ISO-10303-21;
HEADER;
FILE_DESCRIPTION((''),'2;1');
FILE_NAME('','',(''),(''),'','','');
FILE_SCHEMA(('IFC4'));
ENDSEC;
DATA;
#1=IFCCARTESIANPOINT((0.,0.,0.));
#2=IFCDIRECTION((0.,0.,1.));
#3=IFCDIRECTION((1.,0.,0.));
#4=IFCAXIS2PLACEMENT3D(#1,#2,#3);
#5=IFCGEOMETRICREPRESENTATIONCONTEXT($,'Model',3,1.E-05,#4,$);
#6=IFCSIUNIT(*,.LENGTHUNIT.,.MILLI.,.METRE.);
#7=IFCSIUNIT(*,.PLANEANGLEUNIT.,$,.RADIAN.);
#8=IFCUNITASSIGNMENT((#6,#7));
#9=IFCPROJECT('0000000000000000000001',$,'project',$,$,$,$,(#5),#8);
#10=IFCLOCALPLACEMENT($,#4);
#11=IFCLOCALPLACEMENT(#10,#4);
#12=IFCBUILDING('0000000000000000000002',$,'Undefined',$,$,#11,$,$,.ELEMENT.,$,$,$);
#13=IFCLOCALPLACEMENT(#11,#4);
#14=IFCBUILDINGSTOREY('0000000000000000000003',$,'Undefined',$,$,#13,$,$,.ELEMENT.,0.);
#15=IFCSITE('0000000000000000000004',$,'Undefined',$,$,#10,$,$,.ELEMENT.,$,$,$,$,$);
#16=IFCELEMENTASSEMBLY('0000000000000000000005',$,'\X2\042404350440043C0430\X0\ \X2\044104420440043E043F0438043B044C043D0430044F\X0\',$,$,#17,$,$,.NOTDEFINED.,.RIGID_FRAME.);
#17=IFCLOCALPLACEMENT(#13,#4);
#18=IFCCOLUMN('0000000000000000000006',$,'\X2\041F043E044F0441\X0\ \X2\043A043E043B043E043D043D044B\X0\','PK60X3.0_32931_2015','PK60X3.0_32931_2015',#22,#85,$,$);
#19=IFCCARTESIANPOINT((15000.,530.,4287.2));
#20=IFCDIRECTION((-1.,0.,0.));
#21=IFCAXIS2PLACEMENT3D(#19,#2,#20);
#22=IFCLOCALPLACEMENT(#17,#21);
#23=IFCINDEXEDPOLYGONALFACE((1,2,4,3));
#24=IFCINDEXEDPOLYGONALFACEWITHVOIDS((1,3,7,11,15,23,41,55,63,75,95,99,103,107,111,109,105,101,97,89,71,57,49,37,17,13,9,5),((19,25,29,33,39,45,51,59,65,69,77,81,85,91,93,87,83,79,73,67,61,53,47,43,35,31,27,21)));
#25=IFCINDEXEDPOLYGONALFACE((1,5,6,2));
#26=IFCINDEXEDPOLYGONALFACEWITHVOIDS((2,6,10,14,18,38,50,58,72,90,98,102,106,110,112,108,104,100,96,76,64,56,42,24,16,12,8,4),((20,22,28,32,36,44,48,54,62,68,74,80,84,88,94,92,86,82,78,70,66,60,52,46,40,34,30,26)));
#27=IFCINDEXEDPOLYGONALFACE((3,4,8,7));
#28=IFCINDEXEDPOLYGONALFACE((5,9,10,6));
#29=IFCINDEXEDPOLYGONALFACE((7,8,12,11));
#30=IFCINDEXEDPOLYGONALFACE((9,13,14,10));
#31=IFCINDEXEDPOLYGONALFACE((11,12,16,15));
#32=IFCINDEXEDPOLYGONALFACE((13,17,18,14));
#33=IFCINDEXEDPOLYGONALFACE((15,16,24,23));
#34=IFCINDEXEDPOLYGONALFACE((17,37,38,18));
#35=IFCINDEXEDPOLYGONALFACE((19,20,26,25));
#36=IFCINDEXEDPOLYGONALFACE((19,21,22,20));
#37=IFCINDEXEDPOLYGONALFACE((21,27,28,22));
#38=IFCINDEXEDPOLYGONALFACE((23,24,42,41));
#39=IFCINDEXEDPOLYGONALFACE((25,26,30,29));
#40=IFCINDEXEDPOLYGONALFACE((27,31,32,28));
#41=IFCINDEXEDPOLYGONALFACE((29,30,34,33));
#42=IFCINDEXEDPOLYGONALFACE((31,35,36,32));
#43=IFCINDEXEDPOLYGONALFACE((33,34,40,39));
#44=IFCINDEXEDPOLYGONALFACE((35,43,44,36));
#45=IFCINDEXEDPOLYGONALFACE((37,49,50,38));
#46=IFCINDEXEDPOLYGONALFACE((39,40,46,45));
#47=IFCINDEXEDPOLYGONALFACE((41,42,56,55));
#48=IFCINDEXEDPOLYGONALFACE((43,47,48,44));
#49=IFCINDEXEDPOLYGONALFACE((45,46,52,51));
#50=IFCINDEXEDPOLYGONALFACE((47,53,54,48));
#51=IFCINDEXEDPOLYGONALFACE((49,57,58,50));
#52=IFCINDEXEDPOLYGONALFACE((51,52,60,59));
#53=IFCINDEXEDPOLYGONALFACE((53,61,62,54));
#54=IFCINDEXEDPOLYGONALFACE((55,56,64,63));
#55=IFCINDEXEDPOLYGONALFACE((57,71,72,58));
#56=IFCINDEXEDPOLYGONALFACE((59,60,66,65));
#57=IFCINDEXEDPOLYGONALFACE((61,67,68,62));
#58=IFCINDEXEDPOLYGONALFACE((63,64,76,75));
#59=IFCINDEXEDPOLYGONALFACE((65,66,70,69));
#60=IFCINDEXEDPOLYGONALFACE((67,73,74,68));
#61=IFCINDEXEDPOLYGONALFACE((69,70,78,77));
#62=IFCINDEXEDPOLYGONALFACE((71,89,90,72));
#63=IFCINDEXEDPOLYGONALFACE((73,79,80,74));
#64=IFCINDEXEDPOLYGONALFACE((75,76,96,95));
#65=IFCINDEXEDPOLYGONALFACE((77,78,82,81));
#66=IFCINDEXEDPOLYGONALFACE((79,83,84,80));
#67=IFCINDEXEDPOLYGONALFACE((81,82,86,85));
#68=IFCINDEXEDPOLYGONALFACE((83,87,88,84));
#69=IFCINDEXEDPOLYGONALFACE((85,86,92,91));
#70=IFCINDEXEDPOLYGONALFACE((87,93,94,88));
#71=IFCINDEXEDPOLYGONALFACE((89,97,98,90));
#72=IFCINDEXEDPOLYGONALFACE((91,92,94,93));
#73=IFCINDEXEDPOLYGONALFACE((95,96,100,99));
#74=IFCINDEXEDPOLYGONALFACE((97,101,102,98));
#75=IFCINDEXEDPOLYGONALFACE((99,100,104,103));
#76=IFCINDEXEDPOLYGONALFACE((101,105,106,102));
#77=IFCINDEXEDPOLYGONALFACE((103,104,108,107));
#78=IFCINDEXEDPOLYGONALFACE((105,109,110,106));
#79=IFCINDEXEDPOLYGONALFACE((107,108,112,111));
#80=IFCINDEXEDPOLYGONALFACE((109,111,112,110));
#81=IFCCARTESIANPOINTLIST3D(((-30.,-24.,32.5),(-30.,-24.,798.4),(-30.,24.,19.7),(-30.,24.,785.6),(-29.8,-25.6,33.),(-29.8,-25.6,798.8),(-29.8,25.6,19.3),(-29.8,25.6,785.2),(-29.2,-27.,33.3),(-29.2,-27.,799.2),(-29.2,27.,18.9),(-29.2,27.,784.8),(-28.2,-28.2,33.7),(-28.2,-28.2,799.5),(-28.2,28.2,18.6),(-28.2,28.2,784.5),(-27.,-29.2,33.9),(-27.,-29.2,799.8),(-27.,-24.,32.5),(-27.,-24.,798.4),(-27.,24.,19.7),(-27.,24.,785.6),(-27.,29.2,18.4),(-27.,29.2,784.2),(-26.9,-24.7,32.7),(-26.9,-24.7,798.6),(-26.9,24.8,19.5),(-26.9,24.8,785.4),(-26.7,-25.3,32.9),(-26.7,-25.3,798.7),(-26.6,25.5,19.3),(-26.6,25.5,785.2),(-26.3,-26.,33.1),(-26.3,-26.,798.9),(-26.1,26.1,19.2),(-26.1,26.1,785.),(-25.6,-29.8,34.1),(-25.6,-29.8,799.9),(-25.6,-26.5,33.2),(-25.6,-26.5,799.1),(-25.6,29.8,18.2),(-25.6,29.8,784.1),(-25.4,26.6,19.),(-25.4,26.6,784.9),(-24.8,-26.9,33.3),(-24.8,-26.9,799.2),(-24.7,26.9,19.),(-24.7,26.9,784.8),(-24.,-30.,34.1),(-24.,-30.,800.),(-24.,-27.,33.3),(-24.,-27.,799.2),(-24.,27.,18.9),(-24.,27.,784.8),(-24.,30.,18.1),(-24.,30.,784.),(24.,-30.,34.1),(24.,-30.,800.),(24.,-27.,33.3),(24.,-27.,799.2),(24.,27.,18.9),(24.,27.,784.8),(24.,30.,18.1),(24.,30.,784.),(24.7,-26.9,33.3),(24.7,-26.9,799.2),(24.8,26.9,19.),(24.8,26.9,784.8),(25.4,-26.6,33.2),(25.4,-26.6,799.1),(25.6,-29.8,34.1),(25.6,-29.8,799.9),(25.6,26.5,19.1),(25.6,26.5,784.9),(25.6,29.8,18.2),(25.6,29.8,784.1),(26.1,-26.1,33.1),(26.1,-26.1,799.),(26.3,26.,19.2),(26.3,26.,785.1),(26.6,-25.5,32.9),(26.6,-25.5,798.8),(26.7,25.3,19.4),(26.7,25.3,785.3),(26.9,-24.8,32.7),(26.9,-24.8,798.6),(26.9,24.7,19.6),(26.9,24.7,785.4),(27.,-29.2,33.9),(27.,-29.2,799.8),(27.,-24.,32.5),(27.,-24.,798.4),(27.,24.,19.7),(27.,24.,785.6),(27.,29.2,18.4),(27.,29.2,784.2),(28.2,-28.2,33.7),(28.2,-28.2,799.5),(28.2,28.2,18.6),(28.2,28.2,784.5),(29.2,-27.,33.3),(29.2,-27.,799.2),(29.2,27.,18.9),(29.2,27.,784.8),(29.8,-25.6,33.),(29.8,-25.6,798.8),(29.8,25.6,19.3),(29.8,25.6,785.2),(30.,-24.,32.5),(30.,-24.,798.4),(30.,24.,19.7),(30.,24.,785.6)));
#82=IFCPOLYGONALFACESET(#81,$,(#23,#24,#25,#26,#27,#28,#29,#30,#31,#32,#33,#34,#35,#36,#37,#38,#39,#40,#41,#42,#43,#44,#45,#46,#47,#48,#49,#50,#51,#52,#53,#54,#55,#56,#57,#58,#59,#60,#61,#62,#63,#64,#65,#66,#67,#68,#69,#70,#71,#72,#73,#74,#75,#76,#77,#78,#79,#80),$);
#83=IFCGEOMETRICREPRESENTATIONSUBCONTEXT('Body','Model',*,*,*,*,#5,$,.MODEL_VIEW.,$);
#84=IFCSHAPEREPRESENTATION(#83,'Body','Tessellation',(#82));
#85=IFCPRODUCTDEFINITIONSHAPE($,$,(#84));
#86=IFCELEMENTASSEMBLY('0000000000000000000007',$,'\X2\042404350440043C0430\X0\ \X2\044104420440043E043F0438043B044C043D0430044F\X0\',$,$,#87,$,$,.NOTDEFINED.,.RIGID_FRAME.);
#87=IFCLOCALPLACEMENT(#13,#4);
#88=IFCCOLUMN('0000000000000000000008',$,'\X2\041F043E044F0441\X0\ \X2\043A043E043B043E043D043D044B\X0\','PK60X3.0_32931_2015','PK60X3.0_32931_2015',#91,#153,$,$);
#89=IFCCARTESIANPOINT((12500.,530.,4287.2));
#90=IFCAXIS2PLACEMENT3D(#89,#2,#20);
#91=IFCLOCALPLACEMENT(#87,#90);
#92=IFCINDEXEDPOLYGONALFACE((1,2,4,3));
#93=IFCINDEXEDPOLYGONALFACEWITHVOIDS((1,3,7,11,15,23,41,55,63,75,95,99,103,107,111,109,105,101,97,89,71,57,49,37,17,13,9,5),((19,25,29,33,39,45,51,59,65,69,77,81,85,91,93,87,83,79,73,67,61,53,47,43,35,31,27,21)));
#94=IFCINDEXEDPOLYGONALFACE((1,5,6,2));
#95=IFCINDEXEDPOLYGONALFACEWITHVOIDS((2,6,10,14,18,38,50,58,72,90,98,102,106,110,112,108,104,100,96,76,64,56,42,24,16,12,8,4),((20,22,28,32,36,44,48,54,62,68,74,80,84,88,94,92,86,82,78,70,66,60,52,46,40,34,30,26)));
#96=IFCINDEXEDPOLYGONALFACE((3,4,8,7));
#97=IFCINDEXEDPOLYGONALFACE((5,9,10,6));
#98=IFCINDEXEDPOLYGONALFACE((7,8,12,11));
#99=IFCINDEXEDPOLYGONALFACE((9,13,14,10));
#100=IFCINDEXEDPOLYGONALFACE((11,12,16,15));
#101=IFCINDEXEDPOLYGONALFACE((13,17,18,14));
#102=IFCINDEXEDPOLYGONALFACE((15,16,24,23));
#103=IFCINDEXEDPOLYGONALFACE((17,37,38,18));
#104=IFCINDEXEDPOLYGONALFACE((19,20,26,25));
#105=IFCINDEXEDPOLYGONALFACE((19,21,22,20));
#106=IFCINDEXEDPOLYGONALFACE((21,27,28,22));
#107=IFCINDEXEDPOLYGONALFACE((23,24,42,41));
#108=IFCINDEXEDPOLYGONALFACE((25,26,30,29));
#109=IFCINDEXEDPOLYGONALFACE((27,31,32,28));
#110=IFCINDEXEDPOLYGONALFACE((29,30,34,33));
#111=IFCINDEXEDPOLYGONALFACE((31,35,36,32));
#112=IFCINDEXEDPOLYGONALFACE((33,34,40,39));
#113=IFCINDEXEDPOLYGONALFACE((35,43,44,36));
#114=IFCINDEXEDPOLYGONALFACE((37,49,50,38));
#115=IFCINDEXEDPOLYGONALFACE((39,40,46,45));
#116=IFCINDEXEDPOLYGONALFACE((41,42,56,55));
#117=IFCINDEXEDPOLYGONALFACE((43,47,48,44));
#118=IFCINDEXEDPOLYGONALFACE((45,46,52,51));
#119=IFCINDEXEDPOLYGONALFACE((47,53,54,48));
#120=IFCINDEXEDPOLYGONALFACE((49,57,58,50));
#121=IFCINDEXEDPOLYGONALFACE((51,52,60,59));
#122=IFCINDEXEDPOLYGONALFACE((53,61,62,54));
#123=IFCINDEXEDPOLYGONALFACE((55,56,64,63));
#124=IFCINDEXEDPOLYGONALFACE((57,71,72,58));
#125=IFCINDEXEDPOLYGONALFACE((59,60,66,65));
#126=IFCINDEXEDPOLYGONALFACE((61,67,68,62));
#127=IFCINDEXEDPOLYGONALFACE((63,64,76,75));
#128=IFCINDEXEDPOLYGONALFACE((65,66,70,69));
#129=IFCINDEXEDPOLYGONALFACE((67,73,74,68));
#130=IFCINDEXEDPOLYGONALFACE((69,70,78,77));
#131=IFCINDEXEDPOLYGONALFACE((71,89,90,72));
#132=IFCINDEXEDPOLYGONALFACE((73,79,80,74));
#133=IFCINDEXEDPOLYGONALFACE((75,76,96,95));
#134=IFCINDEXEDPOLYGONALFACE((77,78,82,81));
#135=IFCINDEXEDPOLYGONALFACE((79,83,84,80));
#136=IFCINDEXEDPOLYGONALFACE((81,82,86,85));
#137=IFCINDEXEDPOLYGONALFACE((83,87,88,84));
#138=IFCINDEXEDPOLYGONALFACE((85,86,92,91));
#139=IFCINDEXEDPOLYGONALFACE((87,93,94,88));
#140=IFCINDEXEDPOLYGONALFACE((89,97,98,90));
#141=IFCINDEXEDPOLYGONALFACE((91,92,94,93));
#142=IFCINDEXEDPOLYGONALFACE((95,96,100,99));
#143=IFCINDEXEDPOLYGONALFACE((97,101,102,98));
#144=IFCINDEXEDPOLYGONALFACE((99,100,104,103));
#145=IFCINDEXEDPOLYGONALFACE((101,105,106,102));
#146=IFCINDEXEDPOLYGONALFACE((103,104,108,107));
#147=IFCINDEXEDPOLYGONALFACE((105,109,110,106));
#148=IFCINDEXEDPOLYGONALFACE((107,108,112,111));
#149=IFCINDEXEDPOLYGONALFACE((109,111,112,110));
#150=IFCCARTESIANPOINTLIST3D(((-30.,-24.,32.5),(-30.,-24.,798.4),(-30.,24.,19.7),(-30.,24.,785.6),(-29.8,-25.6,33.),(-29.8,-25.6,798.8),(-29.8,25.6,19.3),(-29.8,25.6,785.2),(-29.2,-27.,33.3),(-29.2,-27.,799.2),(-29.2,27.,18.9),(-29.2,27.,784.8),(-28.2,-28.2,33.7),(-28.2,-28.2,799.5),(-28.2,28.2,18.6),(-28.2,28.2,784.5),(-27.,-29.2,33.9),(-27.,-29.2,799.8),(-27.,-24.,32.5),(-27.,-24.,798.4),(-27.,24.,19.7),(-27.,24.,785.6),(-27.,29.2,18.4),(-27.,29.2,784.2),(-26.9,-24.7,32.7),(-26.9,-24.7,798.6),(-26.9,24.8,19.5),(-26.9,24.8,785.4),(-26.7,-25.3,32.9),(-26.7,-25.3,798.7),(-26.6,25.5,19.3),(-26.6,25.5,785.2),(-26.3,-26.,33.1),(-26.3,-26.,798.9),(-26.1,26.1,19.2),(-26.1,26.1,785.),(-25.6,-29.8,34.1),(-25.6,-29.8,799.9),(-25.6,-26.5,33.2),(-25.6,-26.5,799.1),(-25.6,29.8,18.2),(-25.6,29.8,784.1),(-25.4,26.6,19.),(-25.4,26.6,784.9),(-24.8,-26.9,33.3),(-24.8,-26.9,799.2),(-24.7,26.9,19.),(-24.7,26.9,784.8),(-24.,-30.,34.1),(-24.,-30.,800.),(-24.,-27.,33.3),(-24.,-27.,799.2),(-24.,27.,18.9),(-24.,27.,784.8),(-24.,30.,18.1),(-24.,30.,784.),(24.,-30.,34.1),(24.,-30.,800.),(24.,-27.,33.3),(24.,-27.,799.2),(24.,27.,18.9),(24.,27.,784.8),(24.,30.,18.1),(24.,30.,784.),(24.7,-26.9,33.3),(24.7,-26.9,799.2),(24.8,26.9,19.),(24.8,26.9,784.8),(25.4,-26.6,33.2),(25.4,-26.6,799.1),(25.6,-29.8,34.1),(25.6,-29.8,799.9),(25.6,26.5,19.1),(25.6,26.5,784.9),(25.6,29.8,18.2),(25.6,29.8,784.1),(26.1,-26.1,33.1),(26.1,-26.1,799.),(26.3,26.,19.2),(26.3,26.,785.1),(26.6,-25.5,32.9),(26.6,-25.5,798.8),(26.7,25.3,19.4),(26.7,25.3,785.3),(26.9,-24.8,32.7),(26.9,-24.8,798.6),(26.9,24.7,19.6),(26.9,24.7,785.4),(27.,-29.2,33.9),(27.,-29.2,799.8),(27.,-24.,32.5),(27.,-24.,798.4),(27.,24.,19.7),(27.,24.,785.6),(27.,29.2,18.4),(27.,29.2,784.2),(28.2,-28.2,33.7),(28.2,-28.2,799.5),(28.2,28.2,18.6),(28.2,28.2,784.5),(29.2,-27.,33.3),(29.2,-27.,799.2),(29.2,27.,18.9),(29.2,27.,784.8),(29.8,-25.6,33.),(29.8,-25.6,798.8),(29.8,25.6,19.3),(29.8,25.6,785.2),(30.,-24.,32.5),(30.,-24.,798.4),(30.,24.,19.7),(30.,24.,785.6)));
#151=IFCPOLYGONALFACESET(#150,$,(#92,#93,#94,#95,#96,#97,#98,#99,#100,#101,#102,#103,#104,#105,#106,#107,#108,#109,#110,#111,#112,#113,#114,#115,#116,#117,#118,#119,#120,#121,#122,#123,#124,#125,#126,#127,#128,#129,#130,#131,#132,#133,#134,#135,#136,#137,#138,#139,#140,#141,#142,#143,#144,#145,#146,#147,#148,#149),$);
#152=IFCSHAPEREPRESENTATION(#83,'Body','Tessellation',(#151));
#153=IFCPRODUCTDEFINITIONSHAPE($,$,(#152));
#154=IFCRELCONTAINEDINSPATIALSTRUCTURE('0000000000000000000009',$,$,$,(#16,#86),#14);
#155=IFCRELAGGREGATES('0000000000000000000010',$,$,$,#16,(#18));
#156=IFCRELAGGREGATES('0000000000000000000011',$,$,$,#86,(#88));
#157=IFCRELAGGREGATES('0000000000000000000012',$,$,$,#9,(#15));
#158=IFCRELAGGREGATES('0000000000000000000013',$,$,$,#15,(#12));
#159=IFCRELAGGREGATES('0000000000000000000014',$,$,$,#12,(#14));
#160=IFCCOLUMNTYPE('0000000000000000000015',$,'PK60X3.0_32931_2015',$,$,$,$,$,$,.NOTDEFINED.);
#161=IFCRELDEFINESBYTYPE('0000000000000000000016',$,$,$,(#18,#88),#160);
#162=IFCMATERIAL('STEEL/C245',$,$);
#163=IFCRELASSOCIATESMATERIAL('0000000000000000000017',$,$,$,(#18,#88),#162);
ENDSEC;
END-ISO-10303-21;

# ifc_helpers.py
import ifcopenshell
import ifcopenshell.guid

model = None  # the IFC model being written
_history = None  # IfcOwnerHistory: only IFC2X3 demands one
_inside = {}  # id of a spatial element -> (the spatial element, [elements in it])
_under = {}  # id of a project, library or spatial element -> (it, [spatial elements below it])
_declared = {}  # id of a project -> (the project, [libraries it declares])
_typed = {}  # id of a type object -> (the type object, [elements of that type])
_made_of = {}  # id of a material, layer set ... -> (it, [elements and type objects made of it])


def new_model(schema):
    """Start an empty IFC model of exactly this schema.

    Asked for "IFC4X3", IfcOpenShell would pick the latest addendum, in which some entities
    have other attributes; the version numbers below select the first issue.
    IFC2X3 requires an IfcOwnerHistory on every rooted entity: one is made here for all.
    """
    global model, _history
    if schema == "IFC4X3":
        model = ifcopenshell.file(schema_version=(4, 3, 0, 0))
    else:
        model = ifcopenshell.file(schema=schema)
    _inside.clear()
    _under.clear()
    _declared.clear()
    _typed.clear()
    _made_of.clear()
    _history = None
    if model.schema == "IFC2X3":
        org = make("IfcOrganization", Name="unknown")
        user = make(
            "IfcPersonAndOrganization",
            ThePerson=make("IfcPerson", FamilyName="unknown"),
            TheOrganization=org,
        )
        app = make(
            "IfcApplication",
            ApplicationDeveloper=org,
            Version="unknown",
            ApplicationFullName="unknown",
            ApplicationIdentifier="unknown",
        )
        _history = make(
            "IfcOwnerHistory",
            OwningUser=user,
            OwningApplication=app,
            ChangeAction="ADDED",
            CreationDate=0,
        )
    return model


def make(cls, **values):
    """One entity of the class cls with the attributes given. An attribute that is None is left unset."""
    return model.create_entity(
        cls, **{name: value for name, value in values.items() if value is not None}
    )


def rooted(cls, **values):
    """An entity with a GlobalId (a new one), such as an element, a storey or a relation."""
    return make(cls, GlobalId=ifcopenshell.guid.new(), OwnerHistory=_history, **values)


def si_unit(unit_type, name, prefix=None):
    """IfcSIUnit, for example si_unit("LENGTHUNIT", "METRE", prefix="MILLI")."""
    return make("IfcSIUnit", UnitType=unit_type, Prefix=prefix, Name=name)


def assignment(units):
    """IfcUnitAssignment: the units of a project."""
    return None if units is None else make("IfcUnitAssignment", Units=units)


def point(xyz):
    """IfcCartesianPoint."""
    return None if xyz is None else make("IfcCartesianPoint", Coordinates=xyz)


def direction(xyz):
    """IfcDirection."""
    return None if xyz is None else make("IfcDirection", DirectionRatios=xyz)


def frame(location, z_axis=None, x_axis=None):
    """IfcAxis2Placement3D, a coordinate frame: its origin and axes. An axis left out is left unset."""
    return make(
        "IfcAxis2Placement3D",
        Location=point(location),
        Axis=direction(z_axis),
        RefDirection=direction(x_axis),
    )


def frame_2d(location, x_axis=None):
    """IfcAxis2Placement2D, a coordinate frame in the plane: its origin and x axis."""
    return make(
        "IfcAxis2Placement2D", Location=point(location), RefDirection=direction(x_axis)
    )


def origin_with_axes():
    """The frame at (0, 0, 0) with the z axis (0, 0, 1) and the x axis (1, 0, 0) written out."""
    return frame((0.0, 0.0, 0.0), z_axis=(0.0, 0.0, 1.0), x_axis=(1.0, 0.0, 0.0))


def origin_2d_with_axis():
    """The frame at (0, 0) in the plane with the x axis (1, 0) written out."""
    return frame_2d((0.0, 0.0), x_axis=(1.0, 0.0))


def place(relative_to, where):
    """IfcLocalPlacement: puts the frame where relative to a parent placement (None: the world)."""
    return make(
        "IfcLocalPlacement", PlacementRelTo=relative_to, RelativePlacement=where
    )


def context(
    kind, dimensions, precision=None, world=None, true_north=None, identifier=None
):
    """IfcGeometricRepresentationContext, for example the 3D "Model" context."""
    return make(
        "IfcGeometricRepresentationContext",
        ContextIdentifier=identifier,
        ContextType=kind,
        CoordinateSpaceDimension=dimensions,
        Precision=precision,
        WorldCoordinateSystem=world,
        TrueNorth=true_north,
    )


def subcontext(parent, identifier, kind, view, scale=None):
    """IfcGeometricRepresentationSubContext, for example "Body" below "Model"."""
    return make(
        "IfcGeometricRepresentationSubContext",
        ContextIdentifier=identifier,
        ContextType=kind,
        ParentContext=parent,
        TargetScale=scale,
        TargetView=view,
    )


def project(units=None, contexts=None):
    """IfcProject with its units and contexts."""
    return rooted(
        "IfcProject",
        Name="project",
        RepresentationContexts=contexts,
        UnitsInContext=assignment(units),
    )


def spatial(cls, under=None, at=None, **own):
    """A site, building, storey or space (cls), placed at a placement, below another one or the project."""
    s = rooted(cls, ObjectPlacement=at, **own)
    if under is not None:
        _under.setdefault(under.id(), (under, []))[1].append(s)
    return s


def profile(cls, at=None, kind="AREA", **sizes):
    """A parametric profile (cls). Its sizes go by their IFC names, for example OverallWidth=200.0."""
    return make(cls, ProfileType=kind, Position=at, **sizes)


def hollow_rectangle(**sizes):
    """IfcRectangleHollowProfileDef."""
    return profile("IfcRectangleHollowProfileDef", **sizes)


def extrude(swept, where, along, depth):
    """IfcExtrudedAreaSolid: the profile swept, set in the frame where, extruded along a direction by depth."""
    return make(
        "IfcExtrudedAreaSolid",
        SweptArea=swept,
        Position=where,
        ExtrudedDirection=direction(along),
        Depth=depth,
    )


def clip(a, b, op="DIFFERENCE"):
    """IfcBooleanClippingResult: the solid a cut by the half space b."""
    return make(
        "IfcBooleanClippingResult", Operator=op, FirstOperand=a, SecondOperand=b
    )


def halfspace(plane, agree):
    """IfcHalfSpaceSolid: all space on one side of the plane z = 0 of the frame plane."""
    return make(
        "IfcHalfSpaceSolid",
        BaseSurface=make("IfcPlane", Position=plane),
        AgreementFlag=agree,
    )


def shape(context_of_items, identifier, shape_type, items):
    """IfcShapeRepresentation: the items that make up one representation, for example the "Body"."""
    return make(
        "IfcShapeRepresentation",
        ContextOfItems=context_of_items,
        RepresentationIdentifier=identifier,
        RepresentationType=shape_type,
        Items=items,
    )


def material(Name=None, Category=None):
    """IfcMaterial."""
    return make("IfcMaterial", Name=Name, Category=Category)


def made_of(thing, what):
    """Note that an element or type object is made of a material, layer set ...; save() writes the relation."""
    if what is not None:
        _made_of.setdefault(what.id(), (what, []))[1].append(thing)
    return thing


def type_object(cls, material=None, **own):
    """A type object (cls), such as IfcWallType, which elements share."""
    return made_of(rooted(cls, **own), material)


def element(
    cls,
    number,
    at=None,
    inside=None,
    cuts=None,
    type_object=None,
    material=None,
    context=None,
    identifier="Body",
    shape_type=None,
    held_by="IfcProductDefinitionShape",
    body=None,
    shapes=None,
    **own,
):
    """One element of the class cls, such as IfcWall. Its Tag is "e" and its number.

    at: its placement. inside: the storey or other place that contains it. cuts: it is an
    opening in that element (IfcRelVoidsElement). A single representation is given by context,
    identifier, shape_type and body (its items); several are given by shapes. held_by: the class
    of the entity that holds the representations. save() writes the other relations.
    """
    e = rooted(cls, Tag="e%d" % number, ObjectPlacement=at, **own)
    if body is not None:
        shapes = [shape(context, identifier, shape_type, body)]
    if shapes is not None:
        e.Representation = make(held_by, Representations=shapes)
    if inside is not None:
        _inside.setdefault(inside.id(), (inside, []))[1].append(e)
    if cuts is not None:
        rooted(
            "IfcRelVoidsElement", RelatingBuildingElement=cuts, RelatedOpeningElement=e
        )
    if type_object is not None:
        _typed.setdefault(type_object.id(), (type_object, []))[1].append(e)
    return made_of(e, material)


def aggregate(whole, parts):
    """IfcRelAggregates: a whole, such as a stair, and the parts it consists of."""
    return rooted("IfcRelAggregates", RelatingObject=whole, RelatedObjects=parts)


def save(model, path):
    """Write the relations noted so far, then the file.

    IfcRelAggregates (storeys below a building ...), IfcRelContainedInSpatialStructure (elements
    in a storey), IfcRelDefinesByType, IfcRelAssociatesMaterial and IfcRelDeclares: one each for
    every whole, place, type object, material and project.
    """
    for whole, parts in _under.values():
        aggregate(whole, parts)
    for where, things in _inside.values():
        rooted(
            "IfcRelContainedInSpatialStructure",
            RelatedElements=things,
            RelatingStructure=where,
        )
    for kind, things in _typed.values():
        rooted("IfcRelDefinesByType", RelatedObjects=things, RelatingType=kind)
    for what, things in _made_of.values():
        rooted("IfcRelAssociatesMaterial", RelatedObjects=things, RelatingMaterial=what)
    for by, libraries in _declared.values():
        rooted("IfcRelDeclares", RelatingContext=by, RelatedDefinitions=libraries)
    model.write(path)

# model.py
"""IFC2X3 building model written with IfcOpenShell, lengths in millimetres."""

from ifc_helpers import new_model, si_unit, frame, origin_with_axes, origin_2d_with_axis, place, context, subcontext, project, spatial, hollow_rectangle, extrude, clip, halfspace, material, type_object, element, aggregate, save


model = new_model("IFC2X3")

# Units and contexts
model_context = context("Model", 3, precision=1e-05, world=origin_with_axes())
body_context = subcontext(model_context, "Body", "Model", "MODEL_VIEW")
ifc_project = project(units=[si_unit("LENGTHUNIT", "METRE", prefix="MILLI"), si_unit("PLANEANGLEUNIT", "RADIAN")], contexts=[model_context])

# Site, building, storey
site_placement = place(None, origin_with_axes())
site = spatial("IfcSite", under=ifc_project, at=site_placement, Name="Undefined", CompositionType="ELEMENT")
building_placement = place(site_placement, origin_with_axes())
building = spatial("IfcBuilding", under=site, at=building_placement, Name="Undefined", CompositionType="ELEMENT")
storey_placement = place(building_placement, origin_with_axes())
storey = spatial("IfcBuildingStorey", under=building, at=storey_placement, Name="Undefined", CompositionType="ELEMENT", Elevation=0.0)

# Element assemblies, columns
assembly_1_placement = place(storey_placement, origin_with_axes())
assembly_1 = element("IfcElementAssembly", 1, at=assembly_1_placement, inside=storey, Name="Ферма стропильная", AssemblyPlace="NOTDEFINED", PredefinedType="RIGID_FRAME")
ifc_material_1 = material(Name="STEEL/C245")
column_type = type_object("IfcColumnType", Name="PK60X3.0_32931_2015", PredefinedType="NOTDEFINED")
column_1_placement = place(assembly_1_placement, frame((15000.0, 530.0, 4287.2), z_axis=(0.0, 0.0, 1.0), x_axis=(-1.0, 0.0, 0.0)))
column_1 = element("IfcColumn", 2, at=column_1_placement, type_object=column_type, material=ifc_material_1, Name="Пояс колонны", Description="PK60X3.0_32931_2015", ObjectType="PK60X3.0_32931_2015", context=body_context, shape_type="Clipping", body=[
    clip(clip(extrude(hollow_rectangle(XDim=60.0, YDim=60.0, WallThickness=3.0, InnerFilletRadius=3.0, OuterFilletRadius=6.0, at=origin_2d_with_axis()), frame((0.0, 0.0, 808.2), z_axis=(0.0, 0.0, -1.0), x_axis=(0.0, 1.0, 0.0)), (0.0, 0.0, 1.0), 798.2), halfspace(frame((0.0, 84.9, 769.4), z_axis=(0.0, -0.257663, -0.966235), x_axis=(-1.0, 0.0, 0.0)), True)), halfspace(frame((0.0, 49.4, 13.0), z_axis=(0.0, -0.257663, -0.966235), x_axis=(-1.0, 0.0, 0.0)), False)),
])
assembly_2_placement = place(storey_placement, origin_with_axes())
assembly_2 = element("IfcElementAssembly", 3, at=assembly_2_placement, inside=storey, Name="Ферма стропильная", AssemblyPlace="NOTDEFINED", PredefinedType="RIGID_FRAME")
column_2_placement = place(assembly_2_placement, frame((12500.0, 530.0, 4287.2), z_axis=(0.0, 0.0, 1.0), x_axis=(-1.0, 0.0, 0.0)))
column_2 = element("IfcColumn", 4, at=column_2_placement, type_object=column_type, material=ifc_material_1, Name="Пояс колонны", Description="PK60X3.0_32931_2015", ObjectType="PK60X3.0_32931_2015", context=body_context, shape_type="Clipping", body=[
    clip(clip(extrude(hollow_rectangle(XDim=60.0, YDim=60.0, WallThickness=3.0, InnerFilletRadius=3.0, OuterFilletRadius=6.0, at=origin_2d_with_axis()), frame((0.0, 0.0, 808.2), z_axis=(0.0, 0.0, -1.0), x_axis=(0.0, 1.0, 0.0)), (0.0, 0.0, 1.0), 798.2), halfspace(frame((0.0, 84.9, 769.4), z_axis=(0.0, -0.257663, -0.966235), x_axis=(-1.0, 0.0, 0.0)), True)), halfspace(frame((0.0, 49.4, 13.0), z_axis=(0.0, -0.257663, -0.966235), x_axis=(-1.0, 0.0, 0.0)), False)),
])

aggregate(assembly_1, [column_1])
aggregate(assembly_2, [column_2])

save(model, "model.ifc")
